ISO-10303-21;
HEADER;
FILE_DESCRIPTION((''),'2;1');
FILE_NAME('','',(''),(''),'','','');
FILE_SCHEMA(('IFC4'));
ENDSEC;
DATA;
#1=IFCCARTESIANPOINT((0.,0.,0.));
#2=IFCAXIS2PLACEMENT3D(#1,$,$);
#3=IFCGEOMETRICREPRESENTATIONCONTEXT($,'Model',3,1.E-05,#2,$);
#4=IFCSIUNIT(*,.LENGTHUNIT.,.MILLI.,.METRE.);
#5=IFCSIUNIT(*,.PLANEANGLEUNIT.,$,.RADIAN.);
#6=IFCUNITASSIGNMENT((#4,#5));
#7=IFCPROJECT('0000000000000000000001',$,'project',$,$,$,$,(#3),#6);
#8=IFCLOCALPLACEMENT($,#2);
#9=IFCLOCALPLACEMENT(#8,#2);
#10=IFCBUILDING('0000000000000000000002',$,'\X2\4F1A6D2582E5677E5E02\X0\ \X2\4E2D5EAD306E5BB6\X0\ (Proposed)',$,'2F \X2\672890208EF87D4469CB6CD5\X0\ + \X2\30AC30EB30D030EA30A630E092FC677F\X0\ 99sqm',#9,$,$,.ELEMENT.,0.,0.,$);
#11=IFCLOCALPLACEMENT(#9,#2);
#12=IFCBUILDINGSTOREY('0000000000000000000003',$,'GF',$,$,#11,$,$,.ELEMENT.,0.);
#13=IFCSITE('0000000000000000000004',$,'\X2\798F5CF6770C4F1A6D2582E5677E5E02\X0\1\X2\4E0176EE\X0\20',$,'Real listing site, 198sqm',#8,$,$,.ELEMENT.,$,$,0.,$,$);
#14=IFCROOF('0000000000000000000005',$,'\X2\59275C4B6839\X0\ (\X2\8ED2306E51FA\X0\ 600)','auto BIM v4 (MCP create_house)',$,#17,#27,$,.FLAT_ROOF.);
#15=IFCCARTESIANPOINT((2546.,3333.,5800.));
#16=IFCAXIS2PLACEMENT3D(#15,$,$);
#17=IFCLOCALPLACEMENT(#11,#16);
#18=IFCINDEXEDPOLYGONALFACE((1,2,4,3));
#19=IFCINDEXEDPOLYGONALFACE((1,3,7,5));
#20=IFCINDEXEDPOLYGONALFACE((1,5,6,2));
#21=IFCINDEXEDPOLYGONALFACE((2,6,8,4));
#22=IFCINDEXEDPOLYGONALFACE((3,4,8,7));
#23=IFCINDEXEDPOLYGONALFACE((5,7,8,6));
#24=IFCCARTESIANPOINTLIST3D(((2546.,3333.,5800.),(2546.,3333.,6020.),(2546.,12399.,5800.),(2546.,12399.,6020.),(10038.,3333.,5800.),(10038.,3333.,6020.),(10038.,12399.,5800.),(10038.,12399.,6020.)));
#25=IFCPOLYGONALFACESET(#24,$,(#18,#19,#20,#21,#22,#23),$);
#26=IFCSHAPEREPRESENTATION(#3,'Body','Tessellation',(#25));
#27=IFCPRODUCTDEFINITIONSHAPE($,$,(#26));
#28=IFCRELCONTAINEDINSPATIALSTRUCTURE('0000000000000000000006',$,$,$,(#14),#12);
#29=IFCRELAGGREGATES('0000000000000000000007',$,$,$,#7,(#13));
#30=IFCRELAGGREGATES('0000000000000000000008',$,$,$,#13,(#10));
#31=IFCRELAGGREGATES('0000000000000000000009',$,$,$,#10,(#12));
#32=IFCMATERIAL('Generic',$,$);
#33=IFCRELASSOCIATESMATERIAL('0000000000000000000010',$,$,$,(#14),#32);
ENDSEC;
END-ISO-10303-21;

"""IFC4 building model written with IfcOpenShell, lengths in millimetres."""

from ifc_helpers import new_model, si_unit, frame, frame_2d, origin, place, context, project, spatial, rectangle, extrude, material, element, save


model = new_model("IFC4")

# Units and contexts
model_context = context("Model", 3, precision=1e-05, world=origin())
ifc_project = project(units=[si_unit("LENGTHUNIT", "METRE", prefix="MILLI"), si_unit("PLANEANGLEUNIT", "RADIAN")], contexts=[model_context])

# Site, building, storey
site_placement = place(None, origin())
site = spatial("IfcSite", under=ifc_project, at=site_placement, Name="福島県会津若松市1丁目20", ObjectType="Real listing site, 198sqm", CompositionType="ELEMENT", RefElevation=0.0)
building_placement = place(site_placement, origin())
building = spatial("IfcBuilding", under=site, at=building_placement, Name="会津若松市 中庭の家 (Proposed)", ObjectType="2F 木造軸組構法 + ガルバリウム鋼板 99sqm", CompositionType="ELEMENT", ElevationOfRefHeight=0.0, ElevationOfTerrain=0.0)
storey_placement = place(building_placement, origin())
storey = spatial("IfcBuildingStorey", under=building, at=storey_placement, Name="GF", CompositionType="ELEMENT", Elevation=0.0)

# Shared definitions
ifc_material = material(Name="Generic")

# Roof
roof_placement = place(storey_placement, frame((2546.0, 3333.0, 5800.0)))
element("IfcRoof", 1, at=roof_placement, inside=storey, material=ifc_material, Name="大屋根 (軒の出 600)", Description="auto BIM v4 (MCP create_house)", PredefinedType="FLAT_ROOF", context=model_context, shape_type="SweptSolid", body=[
    extrude(rectangle(XDim=7492.0, YDim=9066.0, at=frame_2d((3746.0, 4533.0))), frame((2546.0, 3333.0, 5800.0)), (0.0, 0.0, 1.0), 220.0),
])

save(model, "model.ifc")
